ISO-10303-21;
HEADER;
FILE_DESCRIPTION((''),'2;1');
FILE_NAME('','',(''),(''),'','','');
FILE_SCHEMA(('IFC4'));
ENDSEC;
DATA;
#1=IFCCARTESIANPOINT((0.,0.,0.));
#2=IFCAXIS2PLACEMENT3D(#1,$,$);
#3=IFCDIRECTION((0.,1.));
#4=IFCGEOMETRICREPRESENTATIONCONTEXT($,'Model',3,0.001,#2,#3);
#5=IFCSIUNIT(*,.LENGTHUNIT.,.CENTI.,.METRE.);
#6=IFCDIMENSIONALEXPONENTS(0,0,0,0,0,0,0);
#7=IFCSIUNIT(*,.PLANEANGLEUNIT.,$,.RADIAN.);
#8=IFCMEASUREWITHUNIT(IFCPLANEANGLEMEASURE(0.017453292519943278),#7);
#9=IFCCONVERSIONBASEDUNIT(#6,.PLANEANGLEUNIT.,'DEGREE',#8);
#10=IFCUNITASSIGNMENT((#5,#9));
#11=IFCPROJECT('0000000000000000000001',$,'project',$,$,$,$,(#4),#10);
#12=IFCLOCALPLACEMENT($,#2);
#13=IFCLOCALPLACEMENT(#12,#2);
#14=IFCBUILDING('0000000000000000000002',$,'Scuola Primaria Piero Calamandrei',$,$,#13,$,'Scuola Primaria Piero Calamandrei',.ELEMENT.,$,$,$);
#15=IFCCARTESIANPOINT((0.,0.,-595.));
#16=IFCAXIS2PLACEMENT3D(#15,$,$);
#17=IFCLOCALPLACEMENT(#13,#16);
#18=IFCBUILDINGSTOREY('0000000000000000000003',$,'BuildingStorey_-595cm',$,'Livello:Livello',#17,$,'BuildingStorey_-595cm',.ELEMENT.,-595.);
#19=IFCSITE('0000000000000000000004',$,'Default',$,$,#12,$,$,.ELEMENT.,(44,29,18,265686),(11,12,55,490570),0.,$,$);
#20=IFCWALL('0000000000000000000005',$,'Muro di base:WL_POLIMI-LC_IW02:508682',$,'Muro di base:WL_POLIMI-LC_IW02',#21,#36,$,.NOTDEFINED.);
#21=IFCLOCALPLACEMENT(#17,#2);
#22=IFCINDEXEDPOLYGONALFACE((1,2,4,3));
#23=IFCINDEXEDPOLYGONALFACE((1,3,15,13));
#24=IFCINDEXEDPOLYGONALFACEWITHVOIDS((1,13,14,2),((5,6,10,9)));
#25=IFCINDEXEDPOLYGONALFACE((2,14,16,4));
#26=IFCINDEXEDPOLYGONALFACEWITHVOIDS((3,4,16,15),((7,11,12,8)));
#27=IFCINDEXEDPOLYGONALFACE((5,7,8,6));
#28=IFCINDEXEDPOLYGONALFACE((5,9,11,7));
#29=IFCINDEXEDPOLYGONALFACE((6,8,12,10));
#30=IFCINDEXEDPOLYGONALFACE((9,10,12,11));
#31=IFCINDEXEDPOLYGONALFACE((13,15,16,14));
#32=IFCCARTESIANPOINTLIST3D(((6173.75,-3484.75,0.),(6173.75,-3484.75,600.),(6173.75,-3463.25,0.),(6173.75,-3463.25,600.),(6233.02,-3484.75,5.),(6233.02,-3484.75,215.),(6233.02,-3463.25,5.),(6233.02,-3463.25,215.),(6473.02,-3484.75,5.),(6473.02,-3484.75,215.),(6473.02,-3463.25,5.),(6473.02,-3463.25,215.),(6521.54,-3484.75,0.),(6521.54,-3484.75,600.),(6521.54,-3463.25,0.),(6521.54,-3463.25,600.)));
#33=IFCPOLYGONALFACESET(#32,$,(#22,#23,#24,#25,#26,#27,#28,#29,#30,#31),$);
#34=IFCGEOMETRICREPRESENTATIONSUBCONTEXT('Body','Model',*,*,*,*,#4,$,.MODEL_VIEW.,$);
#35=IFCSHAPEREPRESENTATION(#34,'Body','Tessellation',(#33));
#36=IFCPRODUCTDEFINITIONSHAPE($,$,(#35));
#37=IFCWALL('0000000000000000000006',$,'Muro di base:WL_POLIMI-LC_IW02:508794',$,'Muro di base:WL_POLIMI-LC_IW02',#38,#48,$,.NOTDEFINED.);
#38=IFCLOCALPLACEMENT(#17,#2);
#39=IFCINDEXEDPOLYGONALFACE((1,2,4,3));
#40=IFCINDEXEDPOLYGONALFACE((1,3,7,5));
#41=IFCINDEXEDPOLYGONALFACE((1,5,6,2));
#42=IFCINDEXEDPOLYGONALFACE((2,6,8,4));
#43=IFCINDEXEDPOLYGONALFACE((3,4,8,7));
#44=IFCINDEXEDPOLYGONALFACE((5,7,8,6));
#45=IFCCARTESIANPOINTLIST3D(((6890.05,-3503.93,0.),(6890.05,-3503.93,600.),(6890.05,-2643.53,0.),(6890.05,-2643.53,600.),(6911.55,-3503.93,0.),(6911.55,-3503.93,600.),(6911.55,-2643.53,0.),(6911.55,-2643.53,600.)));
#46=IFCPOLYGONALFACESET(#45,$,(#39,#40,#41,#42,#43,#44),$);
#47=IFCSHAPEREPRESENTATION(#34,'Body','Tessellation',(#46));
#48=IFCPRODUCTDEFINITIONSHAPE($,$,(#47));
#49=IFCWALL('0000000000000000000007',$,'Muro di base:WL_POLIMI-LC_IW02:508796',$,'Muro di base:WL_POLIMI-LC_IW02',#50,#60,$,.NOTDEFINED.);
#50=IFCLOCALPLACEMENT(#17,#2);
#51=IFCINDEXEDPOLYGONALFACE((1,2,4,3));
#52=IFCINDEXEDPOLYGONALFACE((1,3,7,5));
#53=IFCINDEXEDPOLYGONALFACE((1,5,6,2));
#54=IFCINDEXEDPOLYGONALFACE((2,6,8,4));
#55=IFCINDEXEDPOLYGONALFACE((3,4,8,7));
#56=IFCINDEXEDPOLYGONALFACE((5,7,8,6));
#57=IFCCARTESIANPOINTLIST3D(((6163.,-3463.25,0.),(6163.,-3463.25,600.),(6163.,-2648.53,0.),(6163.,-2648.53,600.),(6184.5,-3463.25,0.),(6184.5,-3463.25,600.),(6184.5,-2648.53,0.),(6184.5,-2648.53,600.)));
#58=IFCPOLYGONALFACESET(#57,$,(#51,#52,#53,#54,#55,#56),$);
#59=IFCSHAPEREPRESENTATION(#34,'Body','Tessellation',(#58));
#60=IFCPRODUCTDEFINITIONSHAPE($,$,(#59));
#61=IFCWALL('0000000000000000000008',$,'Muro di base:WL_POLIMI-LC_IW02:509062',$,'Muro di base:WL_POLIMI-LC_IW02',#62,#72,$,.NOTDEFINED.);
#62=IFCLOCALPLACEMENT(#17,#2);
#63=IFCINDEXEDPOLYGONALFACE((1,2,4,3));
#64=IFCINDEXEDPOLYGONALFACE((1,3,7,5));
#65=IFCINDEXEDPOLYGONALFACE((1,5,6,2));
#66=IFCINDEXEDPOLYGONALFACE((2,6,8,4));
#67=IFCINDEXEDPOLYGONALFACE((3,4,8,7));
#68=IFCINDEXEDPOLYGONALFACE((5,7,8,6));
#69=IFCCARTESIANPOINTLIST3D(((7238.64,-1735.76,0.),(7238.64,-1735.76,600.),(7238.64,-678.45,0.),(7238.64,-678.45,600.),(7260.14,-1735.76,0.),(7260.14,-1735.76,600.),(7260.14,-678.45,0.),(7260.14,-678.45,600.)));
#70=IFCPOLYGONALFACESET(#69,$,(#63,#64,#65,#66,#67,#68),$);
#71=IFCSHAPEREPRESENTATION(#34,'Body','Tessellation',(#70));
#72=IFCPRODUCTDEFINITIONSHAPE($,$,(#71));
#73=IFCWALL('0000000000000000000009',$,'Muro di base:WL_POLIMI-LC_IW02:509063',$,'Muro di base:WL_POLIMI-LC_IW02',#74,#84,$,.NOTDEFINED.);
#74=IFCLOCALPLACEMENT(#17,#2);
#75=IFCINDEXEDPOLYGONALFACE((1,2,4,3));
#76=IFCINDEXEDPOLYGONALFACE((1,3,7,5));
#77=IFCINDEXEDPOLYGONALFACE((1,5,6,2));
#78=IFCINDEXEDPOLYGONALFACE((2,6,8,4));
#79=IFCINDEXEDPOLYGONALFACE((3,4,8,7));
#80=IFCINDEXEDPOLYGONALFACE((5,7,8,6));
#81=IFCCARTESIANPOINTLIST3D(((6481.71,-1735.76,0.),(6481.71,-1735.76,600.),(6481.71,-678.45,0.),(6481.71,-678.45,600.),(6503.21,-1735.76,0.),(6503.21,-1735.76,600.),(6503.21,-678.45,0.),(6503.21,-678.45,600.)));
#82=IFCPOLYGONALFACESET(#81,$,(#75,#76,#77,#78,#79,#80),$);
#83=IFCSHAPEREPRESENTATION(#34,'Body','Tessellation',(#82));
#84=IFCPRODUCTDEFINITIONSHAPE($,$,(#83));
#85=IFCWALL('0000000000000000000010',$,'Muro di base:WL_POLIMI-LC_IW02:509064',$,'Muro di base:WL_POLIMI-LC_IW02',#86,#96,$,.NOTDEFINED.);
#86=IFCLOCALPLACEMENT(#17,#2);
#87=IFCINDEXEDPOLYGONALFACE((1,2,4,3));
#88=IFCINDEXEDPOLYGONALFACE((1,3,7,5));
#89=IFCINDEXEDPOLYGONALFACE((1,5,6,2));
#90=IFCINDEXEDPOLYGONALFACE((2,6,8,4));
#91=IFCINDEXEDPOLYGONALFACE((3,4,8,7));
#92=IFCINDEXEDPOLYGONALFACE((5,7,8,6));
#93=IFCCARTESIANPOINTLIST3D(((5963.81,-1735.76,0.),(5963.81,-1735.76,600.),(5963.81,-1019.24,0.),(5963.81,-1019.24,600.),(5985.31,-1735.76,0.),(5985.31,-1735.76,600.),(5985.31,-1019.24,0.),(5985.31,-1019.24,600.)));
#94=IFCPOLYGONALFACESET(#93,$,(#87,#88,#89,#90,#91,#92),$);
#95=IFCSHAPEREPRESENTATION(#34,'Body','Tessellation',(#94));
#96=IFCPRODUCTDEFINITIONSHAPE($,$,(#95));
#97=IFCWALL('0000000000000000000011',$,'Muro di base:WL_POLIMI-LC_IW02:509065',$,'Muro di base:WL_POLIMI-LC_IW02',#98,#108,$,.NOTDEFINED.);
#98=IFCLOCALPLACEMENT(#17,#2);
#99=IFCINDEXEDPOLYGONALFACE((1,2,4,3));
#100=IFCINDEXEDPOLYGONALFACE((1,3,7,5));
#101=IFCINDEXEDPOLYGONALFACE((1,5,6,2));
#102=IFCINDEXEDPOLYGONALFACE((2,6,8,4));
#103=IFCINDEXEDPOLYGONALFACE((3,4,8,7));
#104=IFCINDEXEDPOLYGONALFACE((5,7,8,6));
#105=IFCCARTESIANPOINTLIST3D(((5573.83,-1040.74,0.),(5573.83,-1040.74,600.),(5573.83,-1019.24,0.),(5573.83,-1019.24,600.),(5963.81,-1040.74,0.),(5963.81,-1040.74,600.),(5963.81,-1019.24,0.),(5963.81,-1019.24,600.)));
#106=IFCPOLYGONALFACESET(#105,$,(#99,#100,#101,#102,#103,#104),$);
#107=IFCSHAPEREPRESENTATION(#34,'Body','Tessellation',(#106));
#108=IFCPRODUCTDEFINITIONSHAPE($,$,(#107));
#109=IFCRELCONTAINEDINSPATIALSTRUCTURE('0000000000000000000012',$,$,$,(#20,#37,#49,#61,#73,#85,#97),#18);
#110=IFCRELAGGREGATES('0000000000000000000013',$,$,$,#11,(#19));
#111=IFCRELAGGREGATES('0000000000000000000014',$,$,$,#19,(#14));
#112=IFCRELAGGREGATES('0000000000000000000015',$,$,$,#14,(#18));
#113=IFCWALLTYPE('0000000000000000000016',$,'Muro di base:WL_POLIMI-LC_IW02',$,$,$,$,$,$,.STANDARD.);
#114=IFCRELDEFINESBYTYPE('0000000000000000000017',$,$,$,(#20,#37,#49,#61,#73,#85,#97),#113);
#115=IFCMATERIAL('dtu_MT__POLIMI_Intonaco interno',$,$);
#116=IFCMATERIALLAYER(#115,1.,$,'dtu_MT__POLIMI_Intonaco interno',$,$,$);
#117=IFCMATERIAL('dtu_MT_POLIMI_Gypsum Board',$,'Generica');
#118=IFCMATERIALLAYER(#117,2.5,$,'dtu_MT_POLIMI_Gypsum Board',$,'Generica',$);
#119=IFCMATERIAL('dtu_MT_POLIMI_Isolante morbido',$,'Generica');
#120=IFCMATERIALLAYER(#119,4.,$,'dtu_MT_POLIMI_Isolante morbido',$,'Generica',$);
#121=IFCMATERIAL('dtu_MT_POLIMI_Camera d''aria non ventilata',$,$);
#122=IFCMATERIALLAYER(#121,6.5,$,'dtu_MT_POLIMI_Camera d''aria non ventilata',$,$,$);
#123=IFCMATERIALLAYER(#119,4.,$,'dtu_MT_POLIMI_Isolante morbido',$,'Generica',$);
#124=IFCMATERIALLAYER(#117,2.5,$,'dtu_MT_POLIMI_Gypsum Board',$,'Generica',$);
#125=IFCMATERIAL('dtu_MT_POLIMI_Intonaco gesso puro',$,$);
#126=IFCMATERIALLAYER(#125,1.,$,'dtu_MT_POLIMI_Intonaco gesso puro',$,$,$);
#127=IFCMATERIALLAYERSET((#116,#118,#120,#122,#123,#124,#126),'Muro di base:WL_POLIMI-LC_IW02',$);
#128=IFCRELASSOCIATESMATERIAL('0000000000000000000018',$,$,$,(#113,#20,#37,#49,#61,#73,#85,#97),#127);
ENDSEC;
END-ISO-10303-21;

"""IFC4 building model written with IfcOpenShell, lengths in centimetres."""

from ifc_helpers import new_model, entity, si_unit, converted_unit, direction, frame, frame_2d, origin, place, context, subcontext, project, spatial, rectangle, extrude, material, layer, layer_set, layer_usage, type_object, element, save


model = new_model("IFC4")

# Units and contexts
model_context = context("Model", 3, precision=0.001, world=origin(), true_north=direction((0.0, 1.0)))
body_context = subcontext(model_context, "Body", "Model", "MODEL_VIEW")
ifc_project = project(units=[si_unit("LENGTHUNIT", "METRE", prefix="CENTI"), converted_unit("PLANEANGLEUNIT", "DEGREE", entity("IfcPlaneAngleMeasure", 0.017453292519943278), si_unit("PLANEANGLEUNIT", "RADIAN"), dimensions=[0, 0, 0, 0, 0, 0, 0])], contexts=[model_context])

# Site, building, storey
site_placement = place(None, origin())
site = spatial("IfcSite", under=ifc_project, at=site_placement, Name="Default", CompositionType="ELEMENT", RefLatitude=(44, 29, 18, 265686), RefLongitude=(11, 12, 55, 490570), RefElevation=0.0)
building_placement = place(site_placement, origin())
building = spatial("IfcBuilding", under=site, at=building_placement, Name="Scuola Primaria Piero Calamandrei", LongName="Scuola Primaria Piero Calamandrei", CompositionType="ELEMENT")
storey_placement = place(building_placement, frame((0.0, 0.0, -595.0)))
storey = spatial("IfcBuildingStorey", under=building, at=storey_placement, Name="BuildingStorey_-595cm", ObjectType="Livello:Livello", LongName="BuildingStorey_-595cm", CompositionType="ELEMENT", Elevation=-595.0)

# Shared definitions
ifc_material_1 = material(Name="dtu_MT__POLIMI_Intonaco interno")
ifc_material_2 = material(Name="dtu_MT_POLIMI_Isolante morbido", Category="Generica")
ifc_material_3 = material(Name="dtu_MT_POLIMI_Gypsum Board", Category="Generica")
ifc_layer_1 = layer(ifc_material_1, 1.0, Name="dtu_MT__POLIMI_Intonaco interno")
ifc_layer_2 = layer(ifc_material_3, 2.5, Name="dtu_MT_POLIMI_Gypsum Board", Category="Generica")
ifc_layer_3 = layer(ifc_material_2, 4.0, Name="dtu_MT_POLIMI_Isolante morbido", Category="Generica")
ifc_material_4 = material(Name="dtu_MT_POLIMI_Camera d'aria non ventilata")
ifc_layer_4 = layer(ifc_material_4, 6.5, Name="dtu_MT_POLIMI_Camera d'aria non ventilata")
ifc_layer_5 = layer(ifc_material_2, 4.0, Name="dtu_MT_POLIMI_Isolante morbido", Category="Generica")
ifc_layer_6 = layer(ifc_material_3, 2.5, Name="dtu_MT_POLIMI_Gypsum Board", Category="Generica")
ifc_material_5 = material(Name="dtu_MT_POLIMI_Intonaco gesso puro")
ifc_layer_7 = layer(ifc_material_5, 1.0, Name="dtu_MT_POLIMI_Intonaco gesso puro")
ifc_layer_set_1 = layer_set([ifc_layer_1, ifc_layer_2, ifc_layer_3, ifc_layer_4, ifc_layer_5, ifc_layer_6, ifc_layer_7], Name="Muro di base:WL_POLIMI-LC_IW02")
wall_type_1 = type_object("IfcWallType", Name="Muro di base:WL_POLIMI-LC_IW02", PredefinedType="STANDARD", material=ifc_layer_set_1)

# Wall, opening
ifc_layer_usage_1 = layer_usage(ifc_layer_set_1, "AXIS2", "NEGATIVE", 10.75)
wall_1_placement = place(storey_placement, frame((6173.75, -3474.0, 0.0)))
wall_1 = element("IfcWall", 1, at=wall_1_placement, inside=storey, type_object=wall_type_1, material=ifc_layer_usage_1, Name="Muro di base:WL_POLIMI-LC_IW02:508682", ObjectType="Muro di base:WL_POLIMI-LC_IW02", PredefinedType="NOTDEFINED", context=body_context, shape_type="SweptSolid", body=[
    extrude(rectangle(XDim=347.8, YDim=21.5, at=frame_2d((173.9, 0.0), x_axis=(-1.0, 0.0))), origin(), (0.0, 0.0, 1.0), 600.0),
])
opening_1_placement = place(wall_1_placement, frame((299.27, 10.75, 5.0)))
element("IfcOpeningElement", 2, at=opening_1_placement, cuts=wall_1, PredefinedType="OPENING", context=body_context, shape_type="SweptSolid", body=[
    extrude(rectangle(XDim=210.0, YDim=240.0, at=frame_2d((105.0, 120.0), x_axis=(-1.0, 0.0))), frame((0.0, 0.0, 0.0), z_axis=(0.0, -1.0, 0.0), x_axis=(0.0, 0.0, 1.0)), (0.0, 0.0, 1.0), 21.5),
])

# Walls
ifc_layer_usage_2 = layer_usage(ifc_layer_set_1, "AXIS2", "NEGATIVE", 10.75)
wall_2_placement = place(storey_placement, frame((6900.8, -2643.53, 0.0), z_axis=(0.0, 0.0, 1.0), x_axis=(0.0, -1.0, 0.0)))
element("IfcWall", 3, at=wall_2_placement, inside=storey, type_object=wall_type_1, material=ifc_layer_usage_2, Name="Muro di base:WL_POLIMI-LC_IW02:508794", ObjectType="Muro di base:WL_POLIMI-LC_IW02", PredefinedType="NOTDEFINED", context=body_context, shape_type="SweptSolid", body=[
    extrude(rectangle(XDim=860.4, YDim=21.5, at=frame_2d((430.2, 0.0), x_axis=(-1.0, 0.0))), origin(), (0.0, 0.0, 1.0), 600.0),
])
ifc_layer_usage_3 = layer_usage(ifc_layer_set_1, "AXIS2", "NEGATIVE", 10.75)
wall_3_placement = place(storey_placement, frame((6173.75, -3463.25, 0.0), z_axis=(0.0, 0.0, 1.0), x_axis=(0.0, 1.0, 0.0)))
element("IfcWall", 4, at=wall_3_placement, inside=storey, type_object=wall_type_1, material=ifc_layer_usage_3, Name="Muro di base:WL_POLIMI-LC_IW02:508796", ObjectType="Muro di base:WL_POLIMI-LC_IW02", PredefinedType="NOTDEFINED", context=body_context, shape_type="SweptSolid", body=[
    extrude(rectangle(XDim=814.72, YDim=21.5, at=frame_2d((407.36, 0.0), x_axis=(-1.0, 0.0))), origin(), (0.0, 0.0, 1.0), 600.0),
])
ifc_layer_usage_4 = layer_usage(ifc_layer_set_1, "AXIS2", "NEGATIVE", 10.75)
wall_4_placement = place(storey_placement, frame((7249.39, -1735.76, 0.0), z_axis=(0.0, 0.0, 1.0), x_axis=(0.0, 1.0, 0.0)))
element("IfcWall", 5, at=wall_4_placement, inside=storey, type_object=wall_type_1, material=ifc_layer_usage_4, Name="Muro di base:WL_POLIMI-LC_IW02:509062", ObjectType="Muro di base:WL_POLIMI-LC_IW02", PredefinedType="NOTDEFINED", context=body_context, shape_type="SweptSolid", body=[
    extrude(rectangle(XDim=1057.31, YDim=21.5, at=frame_2d((528.66, 0.0), x_axis=(-1.0, 0.0))), origin(), (0.0, 0.0, 1.0), 600.0),
])
ifc_layer_usage_5 = layer_usage(ifc_layer_set_1, "AXIS2", "NEGATIVE", 10.75)
wall_5_placement = place(storey_placement, frame((6492.46, -1735.76, 0.0), z_axis=(0.0, 0.0, 1.0), x_axis=(0.0, 1.0, 0.0)))
element("IfcWall", 6, at=wall_5_placement, inside=storey, type_object=wall_type_1, material=ifc_layer_usage_5, Name="Muro di base:WL_POLIMI-LC_IW02:509063", ObjectType="Muro di base:WL_POLIMI-LC_IW02", PredefinedType="NOTDEFINED", context=body_context, shape_type="SweptSolid", body=[
    extrude(rectangle(XDim=1057.31, YDim=21.5, at=frame_2d((528.66, 0.0), x_axis=(-1.0, 0.0))), origin(), (0.0, 0.0, 1.0), 600.0),
])
ifc_layer_usage_6 = layer_usage(ifc_layer_set_1, "AXIS2", "NEGATIVE", 10.75)
wall_6_placement = place(storey_placement, frame((5974.56, -1735.76, 0.0), z_axis=(0.0, 0.0, 1.0), x_axis=(0.0, 1.0, 0.0)))
element("IfcWall", 7, at=wall_6_placement, inside=storey, type_object=wall_type_1, material=ifc_layer_usage_6, Name="Muro di base:WL_POLIMI-LC_IW02:509064", ObjectType="Muro di base:WL_POLIMI-LC_IW02", PredefinedType="NOTDEFINED", context=body_context, shape_type="SweptSolid", body=[
    extrude(rectangle(XDim=716.51, YDim=21.5, at=frame_2d((358.26, 0.0), x_axis=(-1.0, 0.0))), origin(), (0.0, 0.0, 1.0), 600.0),
])
ifc_layer_usage_7 = layer_usage(ifc_layer_set_1, "AXIS2", "NEGATIVE", 10.75)
wall_7_placement = place(storey_placement, frame((5963.81, -1029.99, 0.0), z_axis=(0.0, 0.0, 1.0), x_axis=(-1.0, 0.0, 0.0)))
element("IfcWall", 8, at=wall_7_placement, inside=storey, type_object=wall_type_1, material=ifc_layer_usage_7, Name="Muro di base:WL_POLIMI-LC_IW02:509065", ObjectType="Muro di base:WL_POLIMI-LC_IW02", PredefinedType="NOTDEFINED", context=body_context, shape_type="SweptSolid", body=[
    extrude(rectangle(XDim=389.97, YDim=21.5, at=frame_2d((194.99, 0.0), x_axis=(-1.0, 0.0))), origin(), (0.0, 0.0, 1.0), 600.0),
])

save(model, "model.ifc")
